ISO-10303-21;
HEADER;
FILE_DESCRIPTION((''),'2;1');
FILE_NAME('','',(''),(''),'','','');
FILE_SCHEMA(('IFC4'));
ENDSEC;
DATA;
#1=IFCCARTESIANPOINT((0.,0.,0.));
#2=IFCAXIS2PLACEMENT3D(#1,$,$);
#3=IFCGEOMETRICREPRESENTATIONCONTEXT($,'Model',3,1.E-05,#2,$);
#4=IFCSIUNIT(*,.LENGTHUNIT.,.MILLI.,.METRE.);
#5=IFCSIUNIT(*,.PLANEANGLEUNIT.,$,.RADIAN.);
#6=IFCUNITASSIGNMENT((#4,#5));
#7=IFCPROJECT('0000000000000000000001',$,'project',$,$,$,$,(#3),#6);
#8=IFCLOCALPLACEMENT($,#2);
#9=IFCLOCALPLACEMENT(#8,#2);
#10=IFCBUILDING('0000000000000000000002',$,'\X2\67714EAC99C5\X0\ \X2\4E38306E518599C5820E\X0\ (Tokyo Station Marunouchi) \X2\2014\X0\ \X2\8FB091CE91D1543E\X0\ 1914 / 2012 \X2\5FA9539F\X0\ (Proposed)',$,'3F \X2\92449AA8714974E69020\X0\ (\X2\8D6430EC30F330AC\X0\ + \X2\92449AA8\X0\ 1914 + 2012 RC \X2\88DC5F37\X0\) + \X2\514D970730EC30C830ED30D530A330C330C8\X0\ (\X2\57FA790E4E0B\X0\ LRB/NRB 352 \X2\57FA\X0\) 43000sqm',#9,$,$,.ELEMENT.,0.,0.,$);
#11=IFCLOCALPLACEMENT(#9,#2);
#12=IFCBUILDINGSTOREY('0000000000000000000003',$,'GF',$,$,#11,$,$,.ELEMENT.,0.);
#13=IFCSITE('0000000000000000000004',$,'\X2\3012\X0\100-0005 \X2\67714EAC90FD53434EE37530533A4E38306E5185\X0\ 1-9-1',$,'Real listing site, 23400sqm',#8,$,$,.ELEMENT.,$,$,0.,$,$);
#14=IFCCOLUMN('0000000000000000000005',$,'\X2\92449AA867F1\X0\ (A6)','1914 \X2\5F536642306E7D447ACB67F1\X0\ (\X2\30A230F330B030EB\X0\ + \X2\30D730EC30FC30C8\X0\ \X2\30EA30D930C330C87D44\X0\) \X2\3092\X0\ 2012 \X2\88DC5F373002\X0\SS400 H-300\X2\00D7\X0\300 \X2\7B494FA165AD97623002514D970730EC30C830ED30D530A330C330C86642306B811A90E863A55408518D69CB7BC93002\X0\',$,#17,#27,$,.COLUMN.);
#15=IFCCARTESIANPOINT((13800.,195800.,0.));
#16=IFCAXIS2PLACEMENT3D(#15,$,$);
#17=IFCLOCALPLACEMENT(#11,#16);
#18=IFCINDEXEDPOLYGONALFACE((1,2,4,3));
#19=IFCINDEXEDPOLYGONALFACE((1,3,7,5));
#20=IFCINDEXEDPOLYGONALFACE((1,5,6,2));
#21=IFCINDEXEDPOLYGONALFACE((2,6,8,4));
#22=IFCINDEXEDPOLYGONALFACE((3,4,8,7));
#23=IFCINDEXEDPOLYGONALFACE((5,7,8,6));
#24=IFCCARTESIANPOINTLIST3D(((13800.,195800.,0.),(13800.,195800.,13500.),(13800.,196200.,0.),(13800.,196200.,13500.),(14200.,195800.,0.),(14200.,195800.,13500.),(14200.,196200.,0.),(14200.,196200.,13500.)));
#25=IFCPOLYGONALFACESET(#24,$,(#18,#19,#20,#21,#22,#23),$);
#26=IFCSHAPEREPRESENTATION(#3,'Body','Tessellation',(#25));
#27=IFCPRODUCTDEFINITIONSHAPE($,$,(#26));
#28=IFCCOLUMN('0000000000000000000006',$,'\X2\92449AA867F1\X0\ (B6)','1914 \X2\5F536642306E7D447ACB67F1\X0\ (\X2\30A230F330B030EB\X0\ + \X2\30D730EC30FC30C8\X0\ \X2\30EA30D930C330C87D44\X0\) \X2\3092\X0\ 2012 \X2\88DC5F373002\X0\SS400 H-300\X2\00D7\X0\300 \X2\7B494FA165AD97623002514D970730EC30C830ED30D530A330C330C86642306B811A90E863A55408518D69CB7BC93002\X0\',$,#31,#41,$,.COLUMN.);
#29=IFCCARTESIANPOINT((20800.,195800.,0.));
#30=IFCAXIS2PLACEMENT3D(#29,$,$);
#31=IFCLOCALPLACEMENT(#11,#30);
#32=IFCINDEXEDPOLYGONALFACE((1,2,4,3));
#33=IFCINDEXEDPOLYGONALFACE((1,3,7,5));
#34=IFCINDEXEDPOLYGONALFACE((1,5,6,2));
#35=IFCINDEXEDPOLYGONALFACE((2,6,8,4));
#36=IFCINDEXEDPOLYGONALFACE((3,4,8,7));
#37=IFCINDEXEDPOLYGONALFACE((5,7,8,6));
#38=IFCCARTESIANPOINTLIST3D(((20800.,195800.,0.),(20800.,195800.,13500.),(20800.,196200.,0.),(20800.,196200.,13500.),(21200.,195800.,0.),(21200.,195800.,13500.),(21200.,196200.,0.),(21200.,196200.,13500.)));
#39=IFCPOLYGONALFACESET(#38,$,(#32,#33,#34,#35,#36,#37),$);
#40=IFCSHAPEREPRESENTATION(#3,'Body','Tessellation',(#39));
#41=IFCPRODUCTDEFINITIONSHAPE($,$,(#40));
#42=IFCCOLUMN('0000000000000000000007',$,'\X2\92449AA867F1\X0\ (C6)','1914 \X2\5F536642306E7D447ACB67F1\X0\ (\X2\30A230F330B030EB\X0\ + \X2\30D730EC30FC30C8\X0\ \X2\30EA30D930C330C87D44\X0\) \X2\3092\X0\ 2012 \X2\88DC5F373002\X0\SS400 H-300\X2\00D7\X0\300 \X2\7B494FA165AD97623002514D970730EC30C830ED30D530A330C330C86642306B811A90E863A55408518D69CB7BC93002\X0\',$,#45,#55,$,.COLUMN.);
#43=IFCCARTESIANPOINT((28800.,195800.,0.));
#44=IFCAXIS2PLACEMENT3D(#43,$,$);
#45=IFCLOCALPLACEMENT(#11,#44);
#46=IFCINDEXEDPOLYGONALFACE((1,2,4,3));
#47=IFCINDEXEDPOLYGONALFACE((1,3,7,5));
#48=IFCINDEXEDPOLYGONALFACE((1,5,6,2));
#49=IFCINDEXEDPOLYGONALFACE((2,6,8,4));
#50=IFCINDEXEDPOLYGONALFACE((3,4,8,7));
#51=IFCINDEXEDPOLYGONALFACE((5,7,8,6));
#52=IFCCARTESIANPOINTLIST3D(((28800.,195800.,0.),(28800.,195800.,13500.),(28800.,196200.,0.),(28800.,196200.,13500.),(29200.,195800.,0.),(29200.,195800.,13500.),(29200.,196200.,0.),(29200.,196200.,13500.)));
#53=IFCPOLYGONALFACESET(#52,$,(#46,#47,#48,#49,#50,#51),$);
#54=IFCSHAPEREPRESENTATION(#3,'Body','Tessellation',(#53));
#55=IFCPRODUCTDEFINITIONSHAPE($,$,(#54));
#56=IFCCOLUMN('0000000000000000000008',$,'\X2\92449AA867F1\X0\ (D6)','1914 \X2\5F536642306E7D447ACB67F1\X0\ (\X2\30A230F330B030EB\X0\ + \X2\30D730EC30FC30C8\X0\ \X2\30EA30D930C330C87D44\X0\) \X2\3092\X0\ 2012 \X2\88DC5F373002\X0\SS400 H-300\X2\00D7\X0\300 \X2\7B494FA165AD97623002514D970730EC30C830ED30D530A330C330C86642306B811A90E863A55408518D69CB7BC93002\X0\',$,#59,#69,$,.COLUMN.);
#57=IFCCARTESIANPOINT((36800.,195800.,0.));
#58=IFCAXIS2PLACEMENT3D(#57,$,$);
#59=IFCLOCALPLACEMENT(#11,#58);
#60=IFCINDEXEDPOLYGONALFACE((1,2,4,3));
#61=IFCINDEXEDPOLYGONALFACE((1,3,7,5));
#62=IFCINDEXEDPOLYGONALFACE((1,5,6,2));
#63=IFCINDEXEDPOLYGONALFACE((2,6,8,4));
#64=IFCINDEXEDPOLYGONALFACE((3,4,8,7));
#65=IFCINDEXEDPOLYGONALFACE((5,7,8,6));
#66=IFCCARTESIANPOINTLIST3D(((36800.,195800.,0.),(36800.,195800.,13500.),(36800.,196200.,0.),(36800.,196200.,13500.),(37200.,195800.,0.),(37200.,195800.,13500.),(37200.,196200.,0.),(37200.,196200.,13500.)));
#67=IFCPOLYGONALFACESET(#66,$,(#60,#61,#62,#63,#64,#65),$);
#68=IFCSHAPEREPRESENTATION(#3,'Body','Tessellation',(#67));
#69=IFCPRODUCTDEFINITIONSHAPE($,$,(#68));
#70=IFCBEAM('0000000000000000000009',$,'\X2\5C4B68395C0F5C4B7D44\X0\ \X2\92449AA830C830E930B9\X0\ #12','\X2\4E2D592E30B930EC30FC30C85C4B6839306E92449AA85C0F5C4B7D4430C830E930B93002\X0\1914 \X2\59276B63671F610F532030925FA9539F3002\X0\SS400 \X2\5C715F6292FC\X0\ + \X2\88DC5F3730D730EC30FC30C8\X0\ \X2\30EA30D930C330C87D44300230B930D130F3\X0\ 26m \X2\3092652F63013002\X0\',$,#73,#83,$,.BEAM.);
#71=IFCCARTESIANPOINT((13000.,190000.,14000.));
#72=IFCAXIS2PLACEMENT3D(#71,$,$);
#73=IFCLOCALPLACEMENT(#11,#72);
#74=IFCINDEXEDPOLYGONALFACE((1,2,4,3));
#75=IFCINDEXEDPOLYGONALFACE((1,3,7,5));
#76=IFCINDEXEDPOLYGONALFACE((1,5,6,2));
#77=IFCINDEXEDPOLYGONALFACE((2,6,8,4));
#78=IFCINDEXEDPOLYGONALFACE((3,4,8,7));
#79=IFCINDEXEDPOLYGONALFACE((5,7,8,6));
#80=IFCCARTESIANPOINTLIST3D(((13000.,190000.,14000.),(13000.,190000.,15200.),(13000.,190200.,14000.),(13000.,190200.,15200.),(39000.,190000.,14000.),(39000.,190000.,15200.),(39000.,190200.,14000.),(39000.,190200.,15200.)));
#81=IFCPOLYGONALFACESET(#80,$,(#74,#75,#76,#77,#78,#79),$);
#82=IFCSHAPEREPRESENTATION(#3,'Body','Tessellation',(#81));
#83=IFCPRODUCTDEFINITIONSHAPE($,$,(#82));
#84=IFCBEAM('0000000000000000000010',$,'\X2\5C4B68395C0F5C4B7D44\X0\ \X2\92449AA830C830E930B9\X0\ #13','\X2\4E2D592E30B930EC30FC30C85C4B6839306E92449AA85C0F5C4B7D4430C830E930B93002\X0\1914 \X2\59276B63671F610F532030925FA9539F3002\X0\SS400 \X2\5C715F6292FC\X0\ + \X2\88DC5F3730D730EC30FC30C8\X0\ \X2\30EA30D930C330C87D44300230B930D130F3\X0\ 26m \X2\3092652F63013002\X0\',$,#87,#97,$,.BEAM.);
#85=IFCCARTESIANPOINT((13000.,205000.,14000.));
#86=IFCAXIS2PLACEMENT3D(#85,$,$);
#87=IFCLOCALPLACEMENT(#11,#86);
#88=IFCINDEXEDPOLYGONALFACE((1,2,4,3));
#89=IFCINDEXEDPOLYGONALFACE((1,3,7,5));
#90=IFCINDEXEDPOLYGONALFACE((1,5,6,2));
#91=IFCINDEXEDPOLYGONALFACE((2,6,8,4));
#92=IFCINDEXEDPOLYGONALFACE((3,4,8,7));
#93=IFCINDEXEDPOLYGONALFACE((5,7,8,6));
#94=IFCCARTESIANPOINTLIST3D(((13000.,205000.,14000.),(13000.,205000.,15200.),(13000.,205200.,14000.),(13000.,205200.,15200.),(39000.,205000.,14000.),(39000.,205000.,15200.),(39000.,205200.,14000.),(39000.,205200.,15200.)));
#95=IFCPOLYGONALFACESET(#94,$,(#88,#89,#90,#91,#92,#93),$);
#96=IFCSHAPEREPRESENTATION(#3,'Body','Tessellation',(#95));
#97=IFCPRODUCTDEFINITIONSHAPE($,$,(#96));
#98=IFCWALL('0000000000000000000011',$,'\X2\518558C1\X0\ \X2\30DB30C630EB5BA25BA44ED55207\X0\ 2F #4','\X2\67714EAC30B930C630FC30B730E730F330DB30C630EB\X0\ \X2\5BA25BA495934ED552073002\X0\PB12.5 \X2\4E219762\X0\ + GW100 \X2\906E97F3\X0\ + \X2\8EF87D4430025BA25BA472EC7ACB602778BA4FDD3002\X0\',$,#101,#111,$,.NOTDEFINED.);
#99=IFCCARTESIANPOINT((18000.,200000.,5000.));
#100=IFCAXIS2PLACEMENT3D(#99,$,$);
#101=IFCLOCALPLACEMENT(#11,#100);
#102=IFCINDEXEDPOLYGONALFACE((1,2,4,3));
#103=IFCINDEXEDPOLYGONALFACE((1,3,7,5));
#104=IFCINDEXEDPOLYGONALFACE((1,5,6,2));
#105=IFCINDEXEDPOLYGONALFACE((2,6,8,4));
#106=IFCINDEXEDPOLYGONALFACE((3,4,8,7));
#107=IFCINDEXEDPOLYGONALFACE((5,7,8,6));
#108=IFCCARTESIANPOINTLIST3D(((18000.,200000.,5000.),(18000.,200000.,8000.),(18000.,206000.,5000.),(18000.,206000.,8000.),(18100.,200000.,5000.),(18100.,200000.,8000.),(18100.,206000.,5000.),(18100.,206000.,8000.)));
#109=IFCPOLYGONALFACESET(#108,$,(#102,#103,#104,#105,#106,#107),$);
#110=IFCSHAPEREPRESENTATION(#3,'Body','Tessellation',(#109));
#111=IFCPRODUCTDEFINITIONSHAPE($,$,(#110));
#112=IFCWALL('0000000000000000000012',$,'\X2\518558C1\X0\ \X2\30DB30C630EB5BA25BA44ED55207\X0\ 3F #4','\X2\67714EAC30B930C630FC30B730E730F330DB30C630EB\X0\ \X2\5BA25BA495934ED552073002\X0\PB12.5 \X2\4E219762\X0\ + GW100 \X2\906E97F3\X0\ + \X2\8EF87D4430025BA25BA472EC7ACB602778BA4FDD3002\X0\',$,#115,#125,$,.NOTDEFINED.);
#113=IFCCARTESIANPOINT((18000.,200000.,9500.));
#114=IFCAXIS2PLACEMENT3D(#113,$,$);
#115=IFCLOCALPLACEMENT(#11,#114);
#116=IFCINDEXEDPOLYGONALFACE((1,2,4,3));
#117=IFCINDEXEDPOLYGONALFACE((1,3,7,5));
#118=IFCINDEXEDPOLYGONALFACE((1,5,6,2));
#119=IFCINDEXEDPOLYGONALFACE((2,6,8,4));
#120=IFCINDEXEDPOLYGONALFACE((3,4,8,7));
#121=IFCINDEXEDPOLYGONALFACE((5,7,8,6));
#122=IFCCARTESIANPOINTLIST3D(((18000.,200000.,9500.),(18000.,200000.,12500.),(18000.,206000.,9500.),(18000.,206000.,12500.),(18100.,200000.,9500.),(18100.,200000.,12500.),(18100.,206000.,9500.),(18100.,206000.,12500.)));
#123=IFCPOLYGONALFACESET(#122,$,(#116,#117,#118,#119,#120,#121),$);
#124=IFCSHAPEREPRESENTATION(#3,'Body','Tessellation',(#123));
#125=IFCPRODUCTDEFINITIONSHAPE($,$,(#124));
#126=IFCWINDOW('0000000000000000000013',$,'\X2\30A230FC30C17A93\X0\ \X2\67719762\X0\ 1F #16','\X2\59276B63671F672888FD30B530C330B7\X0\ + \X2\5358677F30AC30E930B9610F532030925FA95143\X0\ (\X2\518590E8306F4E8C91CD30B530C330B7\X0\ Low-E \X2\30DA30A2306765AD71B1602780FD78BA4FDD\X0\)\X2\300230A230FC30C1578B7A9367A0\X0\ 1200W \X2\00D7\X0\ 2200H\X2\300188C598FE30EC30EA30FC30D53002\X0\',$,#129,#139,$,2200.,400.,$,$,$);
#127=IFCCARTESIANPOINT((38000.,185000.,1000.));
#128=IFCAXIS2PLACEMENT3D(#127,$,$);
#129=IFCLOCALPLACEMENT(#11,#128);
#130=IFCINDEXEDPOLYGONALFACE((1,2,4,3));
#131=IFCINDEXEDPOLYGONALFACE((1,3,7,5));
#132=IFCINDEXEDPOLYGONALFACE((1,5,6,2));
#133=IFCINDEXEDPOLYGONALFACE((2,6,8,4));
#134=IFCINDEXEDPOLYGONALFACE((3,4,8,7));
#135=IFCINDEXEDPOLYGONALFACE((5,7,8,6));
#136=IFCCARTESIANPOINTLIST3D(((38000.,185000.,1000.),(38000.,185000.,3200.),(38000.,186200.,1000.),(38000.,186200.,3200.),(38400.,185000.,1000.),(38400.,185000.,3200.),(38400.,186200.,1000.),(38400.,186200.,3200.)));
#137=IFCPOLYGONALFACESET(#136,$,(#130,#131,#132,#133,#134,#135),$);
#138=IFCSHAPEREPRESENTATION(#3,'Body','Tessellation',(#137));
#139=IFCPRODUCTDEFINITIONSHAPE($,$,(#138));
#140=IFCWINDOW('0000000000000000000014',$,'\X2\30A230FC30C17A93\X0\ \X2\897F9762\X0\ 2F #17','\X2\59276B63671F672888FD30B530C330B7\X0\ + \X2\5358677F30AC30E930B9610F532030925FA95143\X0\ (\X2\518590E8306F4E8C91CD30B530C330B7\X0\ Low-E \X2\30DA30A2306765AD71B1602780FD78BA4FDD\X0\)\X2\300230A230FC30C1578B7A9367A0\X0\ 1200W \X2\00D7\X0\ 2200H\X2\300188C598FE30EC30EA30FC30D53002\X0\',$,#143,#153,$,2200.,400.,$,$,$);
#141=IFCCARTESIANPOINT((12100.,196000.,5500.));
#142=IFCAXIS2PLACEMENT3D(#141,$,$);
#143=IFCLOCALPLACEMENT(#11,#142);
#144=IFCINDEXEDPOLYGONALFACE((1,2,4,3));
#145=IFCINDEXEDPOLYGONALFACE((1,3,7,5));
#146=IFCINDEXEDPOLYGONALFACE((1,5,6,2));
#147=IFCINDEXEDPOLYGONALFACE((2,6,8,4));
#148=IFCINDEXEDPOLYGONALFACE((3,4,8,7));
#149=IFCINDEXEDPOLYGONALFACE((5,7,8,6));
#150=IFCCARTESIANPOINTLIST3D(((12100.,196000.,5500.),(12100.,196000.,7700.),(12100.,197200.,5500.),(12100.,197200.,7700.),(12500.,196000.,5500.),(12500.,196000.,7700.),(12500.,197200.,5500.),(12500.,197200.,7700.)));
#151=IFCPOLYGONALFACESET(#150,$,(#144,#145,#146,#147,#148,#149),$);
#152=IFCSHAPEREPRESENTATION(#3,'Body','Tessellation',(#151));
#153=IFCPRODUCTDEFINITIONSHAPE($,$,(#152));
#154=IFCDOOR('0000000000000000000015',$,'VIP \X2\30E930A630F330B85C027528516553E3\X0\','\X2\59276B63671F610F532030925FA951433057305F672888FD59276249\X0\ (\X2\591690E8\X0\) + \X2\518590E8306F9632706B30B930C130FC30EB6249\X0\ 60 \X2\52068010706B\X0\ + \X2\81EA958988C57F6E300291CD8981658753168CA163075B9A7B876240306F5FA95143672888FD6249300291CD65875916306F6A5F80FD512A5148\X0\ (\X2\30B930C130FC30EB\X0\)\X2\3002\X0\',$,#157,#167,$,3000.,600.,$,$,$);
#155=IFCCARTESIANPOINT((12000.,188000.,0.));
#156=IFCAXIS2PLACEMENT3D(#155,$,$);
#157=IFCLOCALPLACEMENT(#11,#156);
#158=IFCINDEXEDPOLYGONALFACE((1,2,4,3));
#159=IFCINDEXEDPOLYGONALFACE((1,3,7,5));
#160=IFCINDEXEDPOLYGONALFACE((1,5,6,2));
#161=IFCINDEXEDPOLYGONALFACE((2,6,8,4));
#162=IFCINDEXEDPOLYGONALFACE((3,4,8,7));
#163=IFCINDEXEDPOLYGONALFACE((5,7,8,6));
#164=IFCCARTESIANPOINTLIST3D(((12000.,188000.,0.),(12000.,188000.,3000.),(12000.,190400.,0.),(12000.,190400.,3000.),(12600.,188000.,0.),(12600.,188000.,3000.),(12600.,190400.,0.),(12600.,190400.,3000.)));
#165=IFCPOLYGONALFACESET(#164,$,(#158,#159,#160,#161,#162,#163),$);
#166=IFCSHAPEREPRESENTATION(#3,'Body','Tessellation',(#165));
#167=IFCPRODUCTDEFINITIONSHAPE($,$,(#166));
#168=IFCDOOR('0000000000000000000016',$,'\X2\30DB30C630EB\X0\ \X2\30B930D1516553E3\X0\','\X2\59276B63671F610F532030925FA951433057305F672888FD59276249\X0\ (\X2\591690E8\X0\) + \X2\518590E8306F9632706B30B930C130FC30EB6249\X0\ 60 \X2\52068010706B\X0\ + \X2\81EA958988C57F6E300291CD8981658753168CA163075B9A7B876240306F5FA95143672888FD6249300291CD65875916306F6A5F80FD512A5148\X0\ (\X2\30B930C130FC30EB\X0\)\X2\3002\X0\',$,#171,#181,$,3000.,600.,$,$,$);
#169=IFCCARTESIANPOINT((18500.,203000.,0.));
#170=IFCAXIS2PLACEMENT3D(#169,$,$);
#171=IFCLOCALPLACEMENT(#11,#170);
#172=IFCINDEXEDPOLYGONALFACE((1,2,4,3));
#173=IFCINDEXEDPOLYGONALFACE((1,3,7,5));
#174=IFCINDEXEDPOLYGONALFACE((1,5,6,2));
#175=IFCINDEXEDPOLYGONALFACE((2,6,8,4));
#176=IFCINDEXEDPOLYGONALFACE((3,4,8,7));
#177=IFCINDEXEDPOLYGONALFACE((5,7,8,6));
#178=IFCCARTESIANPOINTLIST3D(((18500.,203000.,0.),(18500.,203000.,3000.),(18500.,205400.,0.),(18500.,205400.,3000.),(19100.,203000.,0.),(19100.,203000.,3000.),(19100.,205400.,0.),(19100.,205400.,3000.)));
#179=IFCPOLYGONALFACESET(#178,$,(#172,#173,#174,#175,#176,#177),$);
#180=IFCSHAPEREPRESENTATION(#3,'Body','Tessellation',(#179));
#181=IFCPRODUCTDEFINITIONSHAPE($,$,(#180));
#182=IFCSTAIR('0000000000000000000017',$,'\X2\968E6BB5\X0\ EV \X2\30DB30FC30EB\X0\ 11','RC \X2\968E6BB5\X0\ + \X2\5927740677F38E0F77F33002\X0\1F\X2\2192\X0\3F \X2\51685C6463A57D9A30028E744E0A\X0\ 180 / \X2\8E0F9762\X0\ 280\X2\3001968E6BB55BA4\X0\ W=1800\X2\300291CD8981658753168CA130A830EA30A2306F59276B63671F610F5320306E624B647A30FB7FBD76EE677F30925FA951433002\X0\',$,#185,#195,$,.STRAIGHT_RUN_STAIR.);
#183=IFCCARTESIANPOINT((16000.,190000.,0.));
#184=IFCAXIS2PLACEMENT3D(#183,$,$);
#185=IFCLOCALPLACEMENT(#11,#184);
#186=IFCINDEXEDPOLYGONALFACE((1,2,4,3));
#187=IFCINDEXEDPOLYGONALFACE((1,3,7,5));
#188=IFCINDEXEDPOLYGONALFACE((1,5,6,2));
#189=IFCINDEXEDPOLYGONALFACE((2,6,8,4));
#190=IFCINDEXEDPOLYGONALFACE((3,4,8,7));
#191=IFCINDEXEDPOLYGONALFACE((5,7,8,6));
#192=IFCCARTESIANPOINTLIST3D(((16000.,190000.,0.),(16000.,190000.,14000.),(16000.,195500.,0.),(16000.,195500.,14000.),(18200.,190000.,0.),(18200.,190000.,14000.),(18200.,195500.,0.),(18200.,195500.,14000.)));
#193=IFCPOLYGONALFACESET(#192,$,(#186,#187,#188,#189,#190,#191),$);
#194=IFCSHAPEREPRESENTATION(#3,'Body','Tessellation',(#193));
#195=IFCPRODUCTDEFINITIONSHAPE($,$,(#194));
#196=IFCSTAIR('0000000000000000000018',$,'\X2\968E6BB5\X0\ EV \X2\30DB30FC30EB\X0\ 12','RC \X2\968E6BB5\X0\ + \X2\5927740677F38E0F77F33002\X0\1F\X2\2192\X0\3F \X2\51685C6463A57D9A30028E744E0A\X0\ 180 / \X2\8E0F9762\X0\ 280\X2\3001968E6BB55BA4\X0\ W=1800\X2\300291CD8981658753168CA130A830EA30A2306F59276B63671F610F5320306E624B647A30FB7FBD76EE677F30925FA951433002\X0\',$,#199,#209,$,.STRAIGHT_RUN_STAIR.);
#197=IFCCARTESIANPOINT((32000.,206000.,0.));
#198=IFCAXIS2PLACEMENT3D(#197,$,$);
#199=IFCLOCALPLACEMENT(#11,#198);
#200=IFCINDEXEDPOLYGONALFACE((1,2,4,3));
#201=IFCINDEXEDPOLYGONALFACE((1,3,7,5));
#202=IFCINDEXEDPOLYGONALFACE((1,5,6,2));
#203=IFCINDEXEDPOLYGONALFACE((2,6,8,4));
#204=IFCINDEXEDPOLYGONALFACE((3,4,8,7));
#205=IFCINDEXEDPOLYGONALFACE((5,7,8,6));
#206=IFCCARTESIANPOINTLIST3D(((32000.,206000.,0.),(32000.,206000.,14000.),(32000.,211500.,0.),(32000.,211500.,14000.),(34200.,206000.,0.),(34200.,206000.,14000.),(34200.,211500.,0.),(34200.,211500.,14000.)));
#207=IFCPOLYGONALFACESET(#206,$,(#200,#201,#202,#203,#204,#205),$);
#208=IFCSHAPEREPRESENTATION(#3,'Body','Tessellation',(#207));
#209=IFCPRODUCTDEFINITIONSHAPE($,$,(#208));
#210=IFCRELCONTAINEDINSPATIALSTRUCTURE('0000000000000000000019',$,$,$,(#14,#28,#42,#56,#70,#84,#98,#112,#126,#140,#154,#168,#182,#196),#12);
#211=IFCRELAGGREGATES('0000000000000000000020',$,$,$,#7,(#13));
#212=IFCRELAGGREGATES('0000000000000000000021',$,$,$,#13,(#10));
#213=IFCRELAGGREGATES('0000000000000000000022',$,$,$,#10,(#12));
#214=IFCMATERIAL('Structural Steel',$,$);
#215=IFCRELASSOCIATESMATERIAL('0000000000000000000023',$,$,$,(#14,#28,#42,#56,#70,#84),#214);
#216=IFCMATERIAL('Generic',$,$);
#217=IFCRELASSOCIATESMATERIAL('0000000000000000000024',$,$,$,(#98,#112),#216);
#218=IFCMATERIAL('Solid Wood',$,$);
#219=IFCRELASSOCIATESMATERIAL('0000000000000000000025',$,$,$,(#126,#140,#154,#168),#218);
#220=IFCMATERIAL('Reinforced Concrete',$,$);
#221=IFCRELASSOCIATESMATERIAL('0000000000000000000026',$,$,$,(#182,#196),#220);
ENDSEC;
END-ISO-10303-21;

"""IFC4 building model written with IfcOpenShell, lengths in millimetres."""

from ifc_helpers import new_model, si_unit, frame, frame_2d, origin, place, context, project, spatial, rectangle, extrude, material, element, save


model = new_model("IFC4")

# Units and contexts
model_context = context("Model", 3, precision=1e-05, world=origin())
ifc_project = project(units=[si_unit("LENGTHUNIT", "METRE", prefix="MILLI"), si_unit("PLANEANGLEUNIT", "RADIAN")], contexts=[model_context])

# Site, building, storey
site_placement = place(None, origin())
site = spatial("IfcSite", under=ifc_project, at=site_placement, Name="〒100-0005 東京都千代田区丸の内 1-9-1", ObjectType="Real listing site, 23400sqm", CompositionType="ELEMENT", RefElevation=0.0)
building_placement = place(site_placement, origin())
building = spatial("IfcBuilding", under=site, at=building_placement, Name="東京駅 丸の内駅舎 (Tokyo Station Marunouchi) — 辰野金吾 1914 / 2012 復原 (Proposed)", ObjectType="3F 鉄骨煉瓦造 (赤レンガ + 鉄骨 1914 + 2012 RC 補強) + 免震レトロフィット (基礎下 LRB/NRB 352 基) 43000sqm", CompositionType="ELEMENT", ElevationOfRefHeight=0.0, ElevationOfTerrain=0.0)
storey_placement = place(building_placement, origin())
storey = spatial("IfcBuildingStorey", under=building, at=storey_placement, Name="GF", CompositionType="ELEMENT", Elevation=0.0)

# Columns
ifc_material_1 = material(Name="Structural Steel")
column_1_placement = place(storey_placement, frame((13800.0, 195800.0, 0.0)))
element("IfcColumn", 1, at=column_1_placement, inside=storey, material=ifc_material_1, Name="鉄骨柱 (A6)", Description="1914 当時の組立柱 (アングル + プレート リベット組) を 2012 補強。SS400 H-300×300 等価断面。免震レトロフィット時に脚部接合再構築。", PredefinedType="COLUMN", context=model_context, shape_type="SweptSolid", body=[
    extrude(rectangle(XDim=400.0, YDim=400.0, at=frame_2d((200.0, 200.0))), frame((13800.0, 195800.0, 0.0)), (0.0, 0.0, 1.0), 13500.0),
])
column_2_placement = place(storey_placement, frame((20800.0, 195800.0, 0.0)))
element("IfcColumn", 2, at=column_2_placement, inside=storey, material=ifc_material_1, Name="鉄骨柱 (B6)", Description="1914 当時の組立柱 (アングル + プレート リベット組) を 2012 補強。SS400 H-300×300 等価断面。免震レトロフィット時に脚部接合再構築。", PredefinedType="COLUMN", context=model_context, shape_type="SweptSolid", body=[
    extrude(rectangle(XDim=400.0, YDim=400.0, at=frame_2d((200.0, 200.0))), frame((20800.0, 195800.0, 0.0)), (0.0, 0.0, 1.0), 13500.0),
])
column_3_placement = place(storey_placement, frame((28800.0, 195800.0, 0.0)))
element("IfcColumn", 3, at=column_3_placement, inside=storey, material=ifc_material_1, Name="鉄骨柱 (C6)", Description="1914 当時の組立柱 (アングル + プレート リベット組) を 2012 補強。SS400 H-300×300 等価断面。免震レトロフィット時に脚部接合再構築。", PredefinedType="COLUMN", context=model_context, shape_type="SweptSolid", body=[
    extrude(rectangle(XDim=400.0, YDim=400.0, at=frame_2d((200.0, 200.0))), frame((28800.0, 195800.0, 0.0)), (0.0, 0.0, 1.0), 13500.0),
])
column_4_placement = place(storey_placement, frame((36800.0, 195800.0, 0.0)))
element("IfcColumn", 4, at=column_4_placement, inside=storey, material=ifc_material_1, Name="鉄骨柱 (D6)", Description="1914 当時の組立柱 (アングル + プレート リベット組) を 2012 補強。SS400 H-300×300 等価断面。免震レトロフィット時に脚部接合再構築。", PredefinedType="COLUMN", context=model_context, shape_type="SweptSolid", body=[
    extrude(rectangle(XDim=400.0, YDim=400.0, at=frame_2d((200.0, 200.0))), frame((36800.0, 195800.0, 0.0)), (0.0, 0.0, 1.0), 13500.0),
])

# Beams
beam_1_placement = place(storey_placement, frame((13000.0, 190000.0, 14000.0)))
element("IfcBeam", 5, at=beam_1_placement, inside=storey, material=ifc_material_1, Name="屋根小屋組 鉄骨トラス #12", Description="中央スレート屋根の鉄骨小屋組トラス。1914 大正期意匠を復原。SS400 山形鋼 + 補強プレート リベット組。スパン 26m を支持。", PredefinedType="BEAM", context=model_context, shape_type="SweptSolid", body=[
    extrude(rectangle(XDim=26000.0, YDim=200.0, at=frame_2d((13000.0, 100.0))), frame((13000.0, 190000.0, 14000.0)), (0.0, 0.0, 1.0), 1200.0),
])
beam_2_placement = place(storey_placement, frame((13000.0, 205000.0, 14000.0)))
element("IfcBeam", 6, at=beam_2_placement, inside=storey, material=ifc_material_1, Name="屋根小屋組 鉄骨トラス #13", Description="中央スレート屋根の鉄骨小屋組トラス。1914 大正期意匠を復原。SS400 山形鋼 + 補強プレート リベット組。スパン 26m を支持。", PredefinedType="BEAM", context=model_context, shape_type="SweptSolid", body=[
    extrude(rectangle(XDim=26000.0, YDim=200.0, at=frame_2d((13000.0, 100.0))), frame((13000.0, 205000.0, 14000.0)), (0.0, 0.0, 1.0), 1200.0),
])

# Walls
ifc_material_2 = material(Name="Generic")
wall_1_placement = place(storey_placement, frame((18000.0, 200000.0, 5000.0)))
element("IfcWall", 7, at=wall_1_placement, inside=storey, material=ifc_material_2, Name="内壁 ホテル客室仕切 2F #4", Description="東京ステーションホテル 客室間仕切。PB12.5 両面 + GW100 遮音 + 軸組。客室独立性確保。", PredefinedType="NOTDEFINED", context=model_context, shape_type="SweptSolid", body=[
    extrude(rectangle(XDim=100.0, YDim=6000.0, at=frame_2d((50.0, 3000.0))), frame((18000.0, 200000.0, 5000.0)), (0.0, 0.0, 1.0), 3000.0),
])
wall_2_placement = place(storey_placement, frame((18000.0, 200000.0, 9500.0)))
element("IfcWall", 8, at=wall_2_placement, inside=storey, material=ifc_material_2, Name="内壁 ホテル客室仕切 3F #4", Description="東京ステーションホテル 客室間仕切。PB12.5 両面 + GW100 遮音 + 軸組。客室独立性確保。", PredefinedType="NOTDEFINED", context=model_context, shape_type="SweptSolid", body=[
    extrude(rectangle(XDim=100.0, YDim=6000.0, at=frame_2d((50.0, 3000.0))), frame((18000.0, 200000.0, 9500.0)), (0.0, 0.0, 1.0), 3000.0),
])

# Windows
ifc_material_3 = material(Name="Solid Wood")
window_1_placement = place(storey_placement, frame((38000.0, 185000.0, 1000.0)))
element("IfcWindow", 9, at=window_1_placement, inside=storey, material=ifc_material_3, Name="アーチ窓 東面 1F #16", Description="大正期木製サッシ + 単板ガラス意匠を復元 (内部は二重サッシ Low-E ペアで断熱性能確保)。アーチ型窓枠 1200W × 2200H、装飾レリーフ。", OverallHeight=2200.0, OverallWidth=400.0, context=model_context, shape_type="SweptSolid", body=[
    extrude(rectangle(XDim=400.0, YDim=1200.0, at=frame_2d((200.0, 600.0))), frame((38000.0, 185000.0, 1000.0)), (0.0, 0.0, 1.0), 2200.0),
])
window_2_placement = place(storey_placement, frame((12100.0, 196000.0, 5500.0)))
element("IfcWindow", 10, at=window_2_placement, inside=storey, material=ifc_material_3, Name="アーチ窓 西面 2F #17", Description="大正期木製サッシ + 単板ガラス意匠を復元 (内部は二重サッシ Low-E ペアで断熱性能確保)。アーチ型窓枠 1200W × 2200H、装飾レリーフ。", OverallHeight=2200.0, OverallWidth=400.0, context=model_context, shape_type="SweptSolid", body=[
    extrude(rectangle(XDim=400.0, YDim=1200.0, at=frame_2d((200.0, 600.0))), frame((12100.0, 196000.0, 5500.0)), (0.0, 0.0, 1.0), 2200.0),
])

# Doors
door_1_placement = place(storey_placement, frame((12000.0, 188000.0, 0.0)))
element("IfcDoor", 11, at=door_1_placement, inside=storey, material=ifc_material_3, Name="VIP ラウンジ専用入口", Description="大正期意匠を復元した木製大扉 (外部) + 内部は防火スチール扉 60 分耐火 + 自閉装置。重要文化財指定箇所は復元木製扉。重文外は機能優先 (スチール)。", OverallHeight=3000.0, OverallWidth=600.0, context=model_context, shape_type="SweptSolid", body=[
    extrude(rectangle(XDim=600.0, YDim=2400.0, at=frame_2d((300.0, 1200.0))), frame((12000.0, 188000.0, 0.0)), (0.0, 0.0, 1.0), 3000.0),
])
door_2_placement = place(storey_placement, frame((18500.0, 203000.0, 0.0)))
element("IfcDoor", 12, at=door_2_placement, inside=storey, material=ifc_material_3, Name="ホテル スパ入口", Description="大正期意匠を復元した木製大扉 (外部) + 内部は防火スチール扉 60 分耐火 + 自閉装置。重要文化財指定箇所は復元木製扉。重文外は機能優先 (スチール)。", OverallHeight=3000.0, OverallWidth=600.0, context=model_context, shape_type="SweptSolid", body=[
    extrude(rectangle(XDim=600.0, YDim=2400.0, at=frame_2d((300.0, 1200.0))), frame((18500.0, 203000.0, 0.0)), (0.0, 0.0, 1.0), 3000.0),
])

# Stairs
ifc_material_4 = material(Name="Reinforced Concrete")
stair_1_placement = place(storey_placement, frame((16000.0, 190000.0, 0.0)))
element("IfcStair", 13, at=stair_1_placement, inside=storey, material=ifc_material_4, Name="階段 EV ホール 11", Description="RC 階段 + 大理石踏石。1F→3F 全層接続。蹴上 180 / 踏面 280、階段室 W=1800。重要文化財エリアは大正期意匠の手摺・羽目板を復元。", PredefinedType="STRAIGHT_RUN_STAIR", context=model_context, shape_type="SweptSolid", body=[
    extrude(rectangle(XDim=2200.0, YDim=5500.0, at=frame_2d((1100.0, 2750.0))), frame((16000.0, 190000.0, 0.0)), (0.0, 0.0, 1.0), 14000.0),
])
stair_2_placement = place(storey_placement, frame((32000.0, 206000.0, 0.0)))
element("IfcStair", 14, at=stair_2_placement, inside=storey, material=ifc_material_4, Name="階段 EV ホール 12", Description="RC 階段 + 大理石踏石。1F→3F 全層接続。蹴上 180 / 踏面 280、階段室 W=1800。重要文化財エリアは大正期意匠の手摺・羽目板を復元。", PredefinedType="STRAIGHT_RUN_STAIR", context=model_context, shape_type="SweptSolid", body=[
    extrude(rectangle(XDim=2200.0, YDim=5500.0, at=frame_2d((1100.0, 2750.0))), frame((32000.0, 206000.0, 0.0)), (0.0, 0.0, 1.0), 14000.0),
])

save(model, "model.ifc")
